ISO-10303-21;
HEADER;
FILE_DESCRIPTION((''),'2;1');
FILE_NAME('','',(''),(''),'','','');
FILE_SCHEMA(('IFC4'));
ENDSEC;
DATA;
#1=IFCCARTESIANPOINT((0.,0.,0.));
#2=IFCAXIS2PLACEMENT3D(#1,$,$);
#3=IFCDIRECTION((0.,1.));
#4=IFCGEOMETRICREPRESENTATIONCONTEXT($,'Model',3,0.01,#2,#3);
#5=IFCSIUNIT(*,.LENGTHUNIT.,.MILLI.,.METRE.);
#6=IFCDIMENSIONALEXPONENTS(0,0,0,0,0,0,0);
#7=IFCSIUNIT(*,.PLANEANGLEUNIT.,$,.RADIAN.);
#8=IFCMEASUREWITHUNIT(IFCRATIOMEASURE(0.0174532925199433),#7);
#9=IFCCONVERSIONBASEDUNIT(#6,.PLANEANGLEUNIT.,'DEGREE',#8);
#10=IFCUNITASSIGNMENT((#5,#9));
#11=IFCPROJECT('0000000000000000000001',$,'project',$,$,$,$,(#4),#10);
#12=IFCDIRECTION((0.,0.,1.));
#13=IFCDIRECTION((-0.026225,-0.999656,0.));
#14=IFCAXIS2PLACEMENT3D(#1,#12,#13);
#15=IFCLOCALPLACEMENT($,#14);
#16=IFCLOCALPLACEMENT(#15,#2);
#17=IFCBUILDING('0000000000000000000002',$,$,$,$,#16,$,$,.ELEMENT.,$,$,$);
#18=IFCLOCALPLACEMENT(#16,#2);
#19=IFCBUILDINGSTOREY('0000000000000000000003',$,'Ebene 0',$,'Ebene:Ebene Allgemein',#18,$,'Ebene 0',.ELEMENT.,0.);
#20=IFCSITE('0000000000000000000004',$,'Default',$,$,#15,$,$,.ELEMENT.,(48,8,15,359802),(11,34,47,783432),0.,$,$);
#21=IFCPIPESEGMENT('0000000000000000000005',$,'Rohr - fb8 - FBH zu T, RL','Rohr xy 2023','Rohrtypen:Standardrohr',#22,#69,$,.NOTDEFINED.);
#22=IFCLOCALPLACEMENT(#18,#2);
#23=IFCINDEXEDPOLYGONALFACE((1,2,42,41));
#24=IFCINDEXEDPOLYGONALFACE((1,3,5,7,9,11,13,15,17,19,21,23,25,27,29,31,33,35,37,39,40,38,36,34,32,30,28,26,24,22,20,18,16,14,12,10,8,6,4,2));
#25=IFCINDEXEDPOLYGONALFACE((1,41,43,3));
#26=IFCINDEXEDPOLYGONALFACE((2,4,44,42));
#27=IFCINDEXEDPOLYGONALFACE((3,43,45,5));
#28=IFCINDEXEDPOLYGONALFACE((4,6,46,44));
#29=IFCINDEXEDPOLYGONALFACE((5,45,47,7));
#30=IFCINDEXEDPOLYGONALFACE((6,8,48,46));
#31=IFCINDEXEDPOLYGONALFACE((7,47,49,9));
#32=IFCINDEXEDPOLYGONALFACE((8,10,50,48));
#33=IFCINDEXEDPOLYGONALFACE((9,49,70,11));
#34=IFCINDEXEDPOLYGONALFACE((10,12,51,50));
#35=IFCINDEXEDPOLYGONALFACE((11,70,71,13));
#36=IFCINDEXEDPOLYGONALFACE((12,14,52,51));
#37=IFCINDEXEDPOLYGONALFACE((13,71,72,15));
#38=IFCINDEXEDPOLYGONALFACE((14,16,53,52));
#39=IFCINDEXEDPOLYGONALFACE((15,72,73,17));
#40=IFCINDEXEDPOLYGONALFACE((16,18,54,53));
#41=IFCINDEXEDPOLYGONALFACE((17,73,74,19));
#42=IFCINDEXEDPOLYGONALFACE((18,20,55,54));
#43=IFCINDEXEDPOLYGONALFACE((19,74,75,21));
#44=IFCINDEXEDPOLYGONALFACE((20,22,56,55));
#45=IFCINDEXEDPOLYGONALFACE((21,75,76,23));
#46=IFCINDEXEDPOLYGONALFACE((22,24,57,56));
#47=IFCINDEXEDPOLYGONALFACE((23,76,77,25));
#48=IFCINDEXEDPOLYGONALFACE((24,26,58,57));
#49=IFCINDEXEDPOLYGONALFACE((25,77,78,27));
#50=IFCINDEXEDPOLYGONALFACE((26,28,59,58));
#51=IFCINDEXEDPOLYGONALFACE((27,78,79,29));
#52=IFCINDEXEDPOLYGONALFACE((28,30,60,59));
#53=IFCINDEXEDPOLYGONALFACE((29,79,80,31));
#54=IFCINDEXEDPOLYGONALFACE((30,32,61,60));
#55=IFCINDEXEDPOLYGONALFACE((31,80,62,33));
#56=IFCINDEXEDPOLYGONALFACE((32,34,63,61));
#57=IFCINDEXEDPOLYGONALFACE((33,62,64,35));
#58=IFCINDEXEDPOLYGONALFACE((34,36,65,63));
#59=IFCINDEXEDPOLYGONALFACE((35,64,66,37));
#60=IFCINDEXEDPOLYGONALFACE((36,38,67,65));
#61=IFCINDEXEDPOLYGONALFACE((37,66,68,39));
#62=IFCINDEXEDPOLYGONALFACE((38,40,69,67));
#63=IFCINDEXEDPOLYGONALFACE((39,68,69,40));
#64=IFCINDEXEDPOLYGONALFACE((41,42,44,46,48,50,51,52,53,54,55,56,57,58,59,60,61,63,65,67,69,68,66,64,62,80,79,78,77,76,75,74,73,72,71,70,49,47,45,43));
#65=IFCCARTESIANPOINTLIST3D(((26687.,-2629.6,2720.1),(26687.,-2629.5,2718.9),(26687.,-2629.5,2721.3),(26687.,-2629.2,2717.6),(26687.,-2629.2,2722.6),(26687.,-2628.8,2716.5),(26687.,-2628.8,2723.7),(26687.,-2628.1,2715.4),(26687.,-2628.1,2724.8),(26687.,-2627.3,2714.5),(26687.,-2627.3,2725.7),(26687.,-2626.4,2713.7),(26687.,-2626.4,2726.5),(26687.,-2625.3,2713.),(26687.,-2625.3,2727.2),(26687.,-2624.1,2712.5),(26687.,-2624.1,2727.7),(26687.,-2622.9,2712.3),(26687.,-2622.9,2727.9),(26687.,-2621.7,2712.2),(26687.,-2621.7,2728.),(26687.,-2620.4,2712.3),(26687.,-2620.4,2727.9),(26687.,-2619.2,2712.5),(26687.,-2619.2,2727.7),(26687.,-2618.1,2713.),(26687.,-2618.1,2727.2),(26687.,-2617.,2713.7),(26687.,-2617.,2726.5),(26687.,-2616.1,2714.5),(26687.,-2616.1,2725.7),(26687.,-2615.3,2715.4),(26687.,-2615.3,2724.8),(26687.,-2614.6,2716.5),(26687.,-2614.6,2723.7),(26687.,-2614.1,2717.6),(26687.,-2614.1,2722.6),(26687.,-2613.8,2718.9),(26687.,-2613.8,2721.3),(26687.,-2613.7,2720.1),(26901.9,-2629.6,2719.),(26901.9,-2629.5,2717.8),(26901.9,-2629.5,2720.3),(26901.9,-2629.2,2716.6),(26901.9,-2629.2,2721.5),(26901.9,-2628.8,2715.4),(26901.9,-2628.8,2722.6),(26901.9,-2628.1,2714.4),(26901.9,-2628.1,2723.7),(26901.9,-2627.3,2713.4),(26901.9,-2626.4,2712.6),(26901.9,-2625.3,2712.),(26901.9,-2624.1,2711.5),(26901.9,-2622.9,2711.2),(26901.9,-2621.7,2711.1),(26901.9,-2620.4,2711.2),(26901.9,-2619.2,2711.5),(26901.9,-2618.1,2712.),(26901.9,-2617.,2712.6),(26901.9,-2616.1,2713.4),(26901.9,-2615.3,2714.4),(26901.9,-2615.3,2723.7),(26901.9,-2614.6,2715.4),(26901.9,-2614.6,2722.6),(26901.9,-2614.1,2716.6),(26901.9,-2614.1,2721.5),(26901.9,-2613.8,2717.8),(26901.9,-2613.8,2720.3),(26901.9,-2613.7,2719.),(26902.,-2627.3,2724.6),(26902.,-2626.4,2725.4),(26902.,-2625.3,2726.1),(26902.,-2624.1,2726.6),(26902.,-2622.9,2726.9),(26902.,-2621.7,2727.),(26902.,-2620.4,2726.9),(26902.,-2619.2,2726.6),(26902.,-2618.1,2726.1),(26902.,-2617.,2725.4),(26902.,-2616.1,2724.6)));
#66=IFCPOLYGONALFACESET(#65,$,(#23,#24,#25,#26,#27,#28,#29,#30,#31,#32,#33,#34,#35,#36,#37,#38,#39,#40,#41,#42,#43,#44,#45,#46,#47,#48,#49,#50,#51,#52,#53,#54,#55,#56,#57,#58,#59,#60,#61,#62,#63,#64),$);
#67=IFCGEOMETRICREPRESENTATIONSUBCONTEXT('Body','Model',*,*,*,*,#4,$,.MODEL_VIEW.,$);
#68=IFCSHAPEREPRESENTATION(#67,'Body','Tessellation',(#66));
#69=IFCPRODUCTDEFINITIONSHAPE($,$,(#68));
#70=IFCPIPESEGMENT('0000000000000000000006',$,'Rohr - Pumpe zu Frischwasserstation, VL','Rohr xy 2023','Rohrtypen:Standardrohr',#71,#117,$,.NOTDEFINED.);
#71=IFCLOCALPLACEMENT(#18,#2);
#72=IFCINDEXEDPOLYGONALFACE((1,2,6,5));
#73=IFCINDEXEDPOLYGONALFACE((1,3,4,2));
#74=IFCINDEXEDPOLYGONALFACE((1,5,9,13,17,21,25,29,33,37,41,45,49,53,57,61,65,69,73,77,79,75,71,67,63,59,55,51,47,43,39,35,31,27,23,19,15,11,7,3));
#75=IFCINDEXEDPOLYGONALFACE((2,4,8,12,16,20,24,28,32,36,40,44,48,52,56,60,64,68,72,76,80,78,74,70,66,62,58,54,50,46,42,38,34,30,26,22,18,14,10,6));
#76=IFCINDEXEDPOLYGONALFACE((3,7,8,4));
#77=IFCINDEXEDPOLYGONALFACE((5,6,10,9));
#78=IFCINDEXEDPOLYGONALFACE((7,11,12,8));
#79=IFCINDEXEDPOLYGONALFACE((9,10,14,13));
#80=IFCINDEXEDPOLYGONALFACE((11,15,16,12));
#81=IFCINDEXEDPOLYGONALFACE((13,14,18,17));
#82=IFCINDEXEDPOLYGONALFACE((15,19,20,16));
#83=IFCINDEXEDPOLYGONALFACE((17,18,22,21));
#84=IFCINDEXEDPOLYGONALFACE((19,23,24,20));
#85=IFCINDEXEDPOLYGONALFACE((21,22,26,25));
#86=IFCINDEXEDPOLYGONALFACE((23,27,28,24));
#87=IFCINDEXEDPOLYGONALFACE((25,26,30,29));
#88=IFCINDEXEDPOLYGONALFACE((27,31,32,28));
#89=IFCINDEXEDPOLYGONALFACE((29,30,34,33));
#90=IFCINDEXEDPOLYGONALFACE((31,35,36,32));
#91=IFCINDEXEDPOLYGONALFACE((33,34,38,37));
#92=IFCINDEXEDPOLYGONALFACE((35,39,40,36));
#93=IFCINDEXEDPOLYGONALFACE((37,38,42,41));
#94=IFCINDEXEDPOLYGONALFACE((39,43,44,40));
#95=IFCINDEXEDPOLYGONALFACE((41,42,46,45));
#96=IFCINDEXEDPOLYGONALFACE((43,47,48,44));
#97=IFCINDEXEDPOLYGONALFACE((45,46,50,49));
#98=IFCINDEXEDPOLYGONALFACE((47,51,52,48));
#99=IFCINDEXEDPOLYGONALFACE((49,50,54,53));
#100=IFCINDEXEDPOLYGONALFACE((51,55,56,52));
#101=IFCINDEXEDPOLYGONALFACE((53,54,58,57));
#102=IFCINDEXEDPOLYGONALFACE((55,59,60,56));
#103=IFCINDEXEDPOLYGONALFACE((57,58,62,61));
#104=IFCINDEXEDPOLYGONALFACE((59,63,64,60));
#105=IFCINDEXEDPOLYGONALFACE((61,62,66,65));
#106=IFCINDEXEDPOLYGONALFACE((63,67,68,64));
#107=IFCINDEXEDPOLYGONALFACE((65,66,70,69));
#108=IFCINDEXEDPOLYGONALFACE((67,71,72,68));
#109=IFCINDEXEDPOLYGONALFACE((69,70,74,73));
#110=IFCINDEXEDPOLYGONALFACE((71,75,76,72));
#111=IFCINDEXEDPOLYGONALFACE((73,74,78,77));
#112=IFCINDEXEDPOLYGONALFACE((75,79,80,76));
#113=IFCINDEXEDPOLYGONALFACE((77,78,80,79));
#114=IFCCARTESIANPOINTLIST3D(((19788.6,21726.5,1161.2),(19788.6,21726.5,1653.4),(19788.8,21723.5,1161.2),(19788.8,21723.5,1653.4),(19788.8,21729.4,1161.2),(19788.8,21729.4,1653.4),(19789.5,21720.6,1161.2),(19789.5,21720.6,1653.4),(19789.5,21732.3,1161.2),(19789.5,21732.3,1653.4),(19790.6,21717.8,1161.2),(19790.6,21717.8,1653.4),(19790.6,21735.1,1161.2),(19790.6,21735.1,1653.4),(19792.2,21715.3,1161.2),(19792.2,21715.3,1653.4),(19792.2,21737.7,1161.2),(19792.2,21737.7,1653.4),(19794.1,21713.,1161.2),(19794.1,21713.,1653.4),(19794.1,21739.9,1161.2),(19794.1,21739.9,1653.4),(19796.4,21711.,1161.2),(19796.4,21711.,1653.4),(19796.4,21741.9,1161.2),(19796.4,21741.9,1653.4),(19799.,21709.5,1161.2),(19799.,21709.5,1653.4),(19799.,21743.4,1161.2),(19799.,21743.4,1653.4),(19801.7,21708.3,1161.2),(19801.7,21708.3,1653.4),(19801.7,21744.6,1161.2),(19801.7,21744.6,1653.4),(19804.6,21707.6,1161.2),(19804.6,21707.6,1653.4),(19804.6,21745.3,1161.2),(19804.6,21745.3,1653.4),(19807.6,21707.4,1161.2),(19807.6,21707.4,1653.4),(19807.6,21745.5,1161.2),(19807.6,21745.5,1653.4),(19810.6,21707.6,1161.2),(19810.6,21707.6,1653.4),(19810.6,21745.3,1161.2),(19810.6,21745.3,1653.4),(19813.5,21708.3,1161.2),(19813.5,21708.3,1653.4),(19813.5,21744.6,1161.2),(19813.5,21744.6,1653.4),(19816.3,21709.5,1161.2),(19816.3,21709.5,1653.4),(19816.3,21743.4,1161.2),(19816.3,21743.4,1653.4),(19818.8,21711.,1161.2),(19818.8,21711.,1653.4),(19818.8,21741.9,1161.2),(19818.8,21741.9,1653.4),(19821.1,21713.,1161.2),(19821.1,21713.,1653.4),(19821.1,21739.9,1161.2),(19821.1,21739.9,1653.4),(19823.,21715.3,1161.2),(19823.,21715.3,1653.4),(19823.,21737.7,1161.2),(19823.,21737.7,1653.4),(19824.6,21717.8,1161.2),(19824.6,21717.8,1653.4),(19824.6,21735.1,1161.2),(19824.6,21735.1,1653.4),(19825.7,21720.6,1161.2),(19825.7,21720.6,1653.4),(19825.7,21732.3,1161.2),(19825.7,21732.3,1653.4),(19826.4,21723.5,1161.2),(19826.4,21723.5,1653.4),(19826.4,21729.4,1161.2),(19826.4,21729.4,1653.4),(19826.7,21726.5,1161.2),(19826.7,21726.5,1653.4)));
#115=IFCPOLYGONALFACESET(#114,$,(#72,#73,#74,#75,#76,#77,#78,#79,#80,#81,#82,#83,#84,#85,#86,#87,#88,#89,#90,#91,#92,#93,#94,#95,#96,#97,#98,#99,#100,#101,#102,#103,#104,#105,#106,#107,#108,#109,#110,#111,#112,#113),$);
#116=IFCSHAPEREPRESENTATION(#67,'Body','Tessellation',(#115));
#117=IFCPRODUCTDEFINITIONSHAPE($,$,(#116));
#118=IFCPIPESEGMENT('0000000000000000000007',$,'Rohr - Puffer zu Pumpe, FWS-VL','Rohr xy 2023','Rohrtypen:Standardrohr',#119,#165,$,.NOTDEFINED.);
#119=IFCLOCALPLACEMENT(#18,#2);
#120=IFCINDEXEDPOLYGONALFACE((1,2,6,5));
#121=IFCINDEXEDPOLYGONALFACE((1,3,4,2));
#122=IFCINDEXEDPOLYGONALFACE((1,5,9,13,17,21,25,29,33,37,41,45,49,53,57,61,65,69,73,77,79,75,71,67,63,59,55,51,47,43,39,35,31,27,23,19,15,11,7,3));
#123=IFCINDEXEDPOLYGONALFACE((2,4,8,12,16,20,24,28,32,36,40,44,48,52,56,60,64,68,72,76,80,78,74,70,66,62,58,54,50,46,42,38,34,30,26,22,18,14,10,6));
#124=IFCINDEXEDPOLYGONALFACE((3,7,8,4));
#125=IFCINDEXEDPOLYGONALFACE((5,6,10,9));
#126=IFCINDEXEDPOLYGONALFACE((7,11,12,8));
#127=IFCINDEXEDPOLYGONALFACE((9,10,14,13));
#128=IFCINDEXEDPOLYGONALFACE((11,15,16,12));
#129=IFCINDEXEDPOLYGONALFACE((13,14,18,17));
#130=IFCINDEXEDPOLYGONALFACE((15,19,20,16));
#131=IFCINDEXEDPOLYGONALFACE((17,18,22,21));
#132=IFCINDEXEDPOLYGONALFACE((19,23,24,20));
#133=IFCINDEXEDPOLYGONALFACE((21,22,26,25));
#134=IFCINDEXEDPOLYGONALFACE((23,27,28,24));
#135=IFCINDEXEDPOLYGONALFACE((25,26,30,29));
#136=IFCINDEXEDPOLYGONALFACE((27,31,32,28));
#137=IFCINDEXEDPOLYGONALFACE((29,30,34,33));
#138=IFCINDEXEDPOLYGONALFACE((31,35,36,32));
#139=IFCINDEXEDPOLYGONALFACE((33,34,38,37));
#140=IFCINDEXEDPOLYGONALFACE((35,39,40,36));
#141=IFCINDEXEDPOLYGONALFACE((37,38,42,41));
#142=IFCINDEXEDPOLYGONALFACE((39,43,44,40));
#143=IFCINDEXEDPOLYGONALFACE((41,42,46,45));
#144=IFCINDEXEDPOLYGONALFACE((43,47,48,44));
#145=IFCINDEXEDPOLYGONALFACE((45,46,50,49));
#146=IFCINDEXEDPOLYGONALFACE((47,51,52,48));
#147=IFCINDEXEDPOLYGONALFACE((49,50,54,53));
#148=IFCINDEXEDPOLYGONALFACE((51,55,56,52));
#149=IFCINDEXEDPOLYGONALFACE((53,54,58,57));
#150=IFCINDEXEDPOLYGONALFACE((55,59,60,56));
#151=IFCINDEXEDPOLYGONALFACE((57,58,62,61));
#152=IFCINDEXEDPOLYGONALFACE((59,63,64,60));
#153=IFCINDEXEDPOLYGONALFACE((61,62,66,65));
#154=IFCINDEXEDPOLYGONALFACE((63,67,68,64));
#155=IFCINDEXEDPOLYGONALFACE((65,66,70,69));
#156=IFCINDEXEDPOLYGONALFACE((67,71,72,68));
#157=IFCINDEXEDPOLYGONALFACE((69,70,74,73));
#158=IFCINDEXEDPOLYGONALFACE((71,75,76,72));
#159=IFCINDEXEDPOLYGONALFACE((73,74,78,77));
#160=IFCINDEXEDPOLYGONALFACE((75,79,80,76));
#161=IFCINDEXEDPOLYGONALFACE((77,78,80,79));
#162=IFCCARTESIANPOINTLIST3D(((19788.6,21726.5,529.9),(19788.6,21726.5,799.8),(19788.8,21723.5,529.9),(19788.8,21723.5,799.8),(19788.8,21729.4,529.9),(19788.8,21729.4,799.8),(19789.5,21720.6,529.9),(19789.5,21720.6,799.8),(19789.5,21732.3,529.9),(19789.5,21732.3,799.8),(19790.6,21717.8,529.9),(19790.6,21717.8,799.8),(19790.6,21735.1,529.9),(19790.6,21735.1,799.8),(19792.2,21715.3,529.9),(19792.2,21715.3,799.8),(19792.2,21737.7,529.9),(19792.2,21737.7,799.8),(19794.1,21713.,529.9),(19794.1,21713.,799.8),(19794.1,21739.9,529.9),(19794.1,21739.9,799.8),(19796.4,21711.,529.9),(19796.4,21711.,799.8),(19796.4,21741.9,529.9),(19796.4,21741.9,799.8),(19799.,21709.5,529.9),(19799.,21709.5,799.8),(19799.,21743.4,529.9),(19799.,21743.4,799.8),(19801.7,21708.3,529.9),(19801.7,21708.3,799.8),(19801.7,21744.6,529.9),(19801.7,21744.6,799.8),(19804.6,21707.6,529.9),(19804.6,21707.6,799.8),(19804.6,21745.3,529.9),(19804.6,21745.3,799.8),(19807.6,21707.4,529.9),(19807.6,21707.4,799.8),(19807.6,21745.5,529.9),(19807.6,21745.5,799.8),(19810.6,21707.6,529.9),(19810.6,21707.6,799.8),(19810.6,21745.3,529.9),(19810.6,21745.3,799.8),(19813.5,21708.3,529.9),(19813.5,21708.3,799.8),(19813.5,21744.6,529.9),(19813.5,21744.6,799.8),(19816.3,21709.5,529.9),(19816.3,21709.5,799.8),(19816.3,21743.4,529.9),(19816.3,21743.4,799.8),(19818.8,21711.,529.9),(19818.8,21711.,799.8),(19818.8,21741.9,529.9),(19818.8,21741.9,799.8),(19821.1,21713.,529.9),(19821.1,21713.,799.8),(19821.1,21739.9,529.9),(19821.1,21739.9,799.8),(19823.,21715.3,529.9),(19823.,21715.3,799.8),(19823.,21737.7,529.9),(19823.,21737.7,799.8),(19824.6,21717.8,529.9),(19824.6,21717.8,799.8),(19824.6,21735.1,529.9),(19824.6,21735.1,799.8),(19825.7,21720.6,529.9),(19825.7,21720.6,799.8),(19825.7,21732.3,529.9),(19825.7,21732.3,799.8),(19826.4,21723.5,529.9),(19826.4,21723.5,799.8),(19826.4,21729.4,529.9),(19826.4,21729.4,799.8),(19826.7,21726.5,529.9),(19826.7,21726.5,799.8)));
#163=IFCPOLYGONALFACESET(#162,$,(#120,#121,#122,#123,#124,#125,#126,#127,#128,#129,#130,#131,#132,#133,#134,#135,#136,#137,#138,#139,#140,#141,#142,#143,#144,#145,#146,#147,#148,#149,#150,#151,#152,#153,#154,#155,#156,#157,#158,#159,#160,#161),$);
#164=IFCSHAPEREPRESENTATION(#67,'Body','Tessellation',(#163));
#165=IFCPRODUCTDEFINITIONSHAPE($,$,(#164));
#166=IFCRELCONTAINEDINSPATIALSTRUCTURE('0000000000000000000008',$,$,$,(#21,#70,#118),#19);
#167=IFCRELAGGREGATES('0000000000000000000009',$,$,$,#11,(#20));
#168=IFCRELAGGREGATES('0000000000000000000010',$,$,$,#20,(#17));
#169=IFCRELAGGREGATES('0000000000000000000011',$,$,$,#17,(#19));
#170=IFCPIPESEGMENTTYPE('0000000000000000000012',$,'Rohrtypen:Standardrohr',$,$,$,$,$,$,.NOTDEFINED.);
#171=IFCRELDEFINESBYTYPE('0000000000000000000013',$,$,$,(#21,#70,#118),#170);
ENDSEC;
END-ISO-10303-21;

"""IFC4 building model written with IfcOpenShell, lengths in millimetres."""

from ifc_helpers import new_model, entity, si_unit, converted_unit, direction, frame, origin, place, context, subcontext, project, spatial, indexed_curve, outline, extrude, type_object, element, save


model = new_model("IFC4")

# Units and contexts
model_context = context("Model", 3, precision=0.01, world=origin(), true_north=direction((0.0, 1.0)))
body_context = subcontext(model_context, "Body", "Model", "MODEL_VIEW")
ifc_project = project(units=[si_unit("LENGTHUNIT", "METRE", prefix="MILLI"), converted_unit("PLANEANGLEUNIT", "DEGREE", entity("IfcRatioMeasure", 0.0174532925199433), si_unit("PLANEANGLEUNIT", "RADIAN"), dimensions=[0, 0, 0, 0, 0, 0, 0])], contexts=[model_context])

# Site, building, storey
site_placement = place(None, frame((0.0, 0.0, 0.0), z_axis=(0.0, 0.0, 1.0), x_axis=(-0.026225, -0.999656, 0.0)))
site = spatial("IfcSite", under=ifc_project, at=site_placement, Name="Default", CompositionType="ELEMENT", RefLatitude=(48, 8, 15, 359802), RefLongitude=(11, 34, 47, 783432), RefElevation=0.0)
building_placement = place(site_placement, origin())
building = spatial("IfcBuilding", under=site, at=building_placement, CompositionType="ELEMENT")
storey_placement = place(building_placement, origin())
storey = spatial("IfcBuildingStorey", under=building, at=storey_placement, Name="Ebene 0", ObjectType="Ebene:Ebene Allgemein", LongName="Ebene 0", CompositionType="ELEMENT", Elevation=0.0)

# Pipe segments
pipe_segment_type = type_object("IfcPipeSegmentType", Name="Rohrtypen:Standardrohr", PredefinedType="NOTDEFINED")
pipe_segment_1_placement = place(storey_placement, origin())
element("IfcPipeSegment", 1, at=pipe_segment_1_placement, inside=storey, type_object=pipe_segment_type, Name="Rohr - fb8 - FBH zu T, RL", Description="Rohr xy 2023", ObjectType="Rohrtypen:Standardrohr", PredefinedType="NOTDEFINED", context=body_context, shape_type="SweptSolid", body=[
    extrude(outline(indexed_curve([(7.9, 0.0), (7.8, 1.2), (7.6, 2.5), (7.1, 3.6), (6.4, 4.7), (5.6, 5.6), (4.7, 6.4), (3.6, 7.1), (2.5, 7.6), (1.2, 7.8), (0.0, 7.9), (-1.2, 7.8), (-2.5, 7.6), (-3.6, 7.1), (-4.7, 6.4), (-5.6, 5.6), (-6.4, 4.7), (-7.1, 3.6), (-7.6, 2.5), (-7.8, 1.2), (-7.9, 0.0), (-7.8, -1.2), (-7.6, -2.5), (-7.1, -3.6), (-6.4, -4.7), (-5.6, -5.6), (-4.7, -6.4), (-3.6, -7.1), (-2.5, -7.6), (-1.2, -7.8), (0.0, -7.9), (1.2, -7.8), (2.5, -7.6), (3.6, -7.1), (4.7, -6.4), (5.6, -5.6), (6.4, -4.7), (7.1, -3.6), (7.6, -2.5), (7.8, -1.2), (7.9, 0.0)], self_intersect=False)), frame((26901.9, -2621.7, 2719.0), z_axis=(-0.999988, 0.0, 0.005), x_axis=(0.0, 1.0, 0.0)), (0.0, 0.0, 1.0), 214.9),
])
pipe_segment_2_placement = place(storey_placement, origin())
element("IfcPipeSegment", 2, at=pipe_segment_2_placement, inside=storey, type_object=pipe_segment_type, Name="Rohr - Pumpe zu Frischwasserstation, VL", Description="Rohr xy 2023", ObjectType="Rohrtypen:Standardrohr", PredefinedType="NOTDEFINED", context=body_context, shape_type="SweptSolid", body=[
    extrude(outline(indexed_curve([(19.1, 0.0), (18.8, 3.0), (18.1, 5.9), (17.0, 8.6), (15.4, 11.2), (13.5, 13.5), (11.2, 15.4), (8.6, 17.0), (5.9, 18.1), (3.0, 18.8), (0.0, 19.0), (-3.0, 18.8), (-5.9, 18.1), (-8.6, 17.0), (-11.2, 15.4), (-13.5, 13.5), (-15.4, 11.2), (-17.0, 8.6), (-18.1, 5.9), (-18.8, 3.0), (-19.1, 0.0), (-18.8, -3.0), (-18.1, -5.9), (-17.0, -8.6), (-15.4, -11.2), (-13.5, -13.5), (-11.2, -15.4), (-8.6, -17.0), (-5.9, -18.1), (-3.0, -18.8), (0.0, -19.0), (3.0, -18.8), (5.9, -18.1), (8.6, -17.0), (11.2, -15.4), (13.5, -13.5), (15.4, -11.2), (17.0, -8.6), (18.1, -5.9), (18.8, -3.0), (19.1, 0.0)], self_intersect=False)), frame((19807.6, 21726.5, 1161.2), z_axis=(0.000002, 0.000002, 1.0), x_axis=(-1.0, 0.0, 0.000002)), (0.0, 0.0, 1.0), 492.1),
])
pipe_segment_3_placement = place(storey_placement, origin())
element("IfcPipeSegment", 3, at=pipe_segment_3_placement, inside=storey, type_object=pipe_segment_type, Name="Rohr - Puffer zu Pumpe, FWS-VL", Description="Rohr xy 2023", ObjectType="Rohrtypen:Standardrohr", PredefinedType="NOTDEFINED", context=body_context, shape_type="SweptSolid", body=[
    extrude(outline(indexed_curve([(19.1, 0.0), (18.8, 3.0), (18.1, 5.9), (17.0, 8.6), (15.4, 11.2), (13.5, 13.5), (11.2, 15.4), (8.6, 17.0), (5.9, 18.1), (3.0, 18.8), (0.0, 19.0), (-3.0, 18.8), (-5.9, 18.1), (-8.6, 17.0), (-11.2, 15.4), (-13.5, 13.5), (-15.4, 11.2), (-17.0, 8.6), (-18.1, 5.9), (-18.8, 3.0), (-19.1, 0.0), (-18.8, -3.0), (-18.1, -5.9), (-17.0, -8.6), (-15.4, -11.2), (-13.5, -13.5), (-11.2, -15.4), (-8.6, -17.0), (-5.9, -18.1), (-3.0, -18.8), (0.0, -19.0), (3.0, -18.8), (5.9, -18.1), (8.6, -17.0), (11.2, -15.4), (13.5, -13.5), (15.4, -11.2), (17.0, -8.6), (18.1, -5.9), (18.8, -3.0), (19.1, 0.0)], self_intersect=False)), frame((19807.6, 21726.5, 529.9), z_axis=(0.000002, 0.000002, 1.0), x_axis=(-1.0, 0.0, 0.000002)), (0.0, 0.0, 1.0), 269.9),
])

save(model, "model.ifc")
